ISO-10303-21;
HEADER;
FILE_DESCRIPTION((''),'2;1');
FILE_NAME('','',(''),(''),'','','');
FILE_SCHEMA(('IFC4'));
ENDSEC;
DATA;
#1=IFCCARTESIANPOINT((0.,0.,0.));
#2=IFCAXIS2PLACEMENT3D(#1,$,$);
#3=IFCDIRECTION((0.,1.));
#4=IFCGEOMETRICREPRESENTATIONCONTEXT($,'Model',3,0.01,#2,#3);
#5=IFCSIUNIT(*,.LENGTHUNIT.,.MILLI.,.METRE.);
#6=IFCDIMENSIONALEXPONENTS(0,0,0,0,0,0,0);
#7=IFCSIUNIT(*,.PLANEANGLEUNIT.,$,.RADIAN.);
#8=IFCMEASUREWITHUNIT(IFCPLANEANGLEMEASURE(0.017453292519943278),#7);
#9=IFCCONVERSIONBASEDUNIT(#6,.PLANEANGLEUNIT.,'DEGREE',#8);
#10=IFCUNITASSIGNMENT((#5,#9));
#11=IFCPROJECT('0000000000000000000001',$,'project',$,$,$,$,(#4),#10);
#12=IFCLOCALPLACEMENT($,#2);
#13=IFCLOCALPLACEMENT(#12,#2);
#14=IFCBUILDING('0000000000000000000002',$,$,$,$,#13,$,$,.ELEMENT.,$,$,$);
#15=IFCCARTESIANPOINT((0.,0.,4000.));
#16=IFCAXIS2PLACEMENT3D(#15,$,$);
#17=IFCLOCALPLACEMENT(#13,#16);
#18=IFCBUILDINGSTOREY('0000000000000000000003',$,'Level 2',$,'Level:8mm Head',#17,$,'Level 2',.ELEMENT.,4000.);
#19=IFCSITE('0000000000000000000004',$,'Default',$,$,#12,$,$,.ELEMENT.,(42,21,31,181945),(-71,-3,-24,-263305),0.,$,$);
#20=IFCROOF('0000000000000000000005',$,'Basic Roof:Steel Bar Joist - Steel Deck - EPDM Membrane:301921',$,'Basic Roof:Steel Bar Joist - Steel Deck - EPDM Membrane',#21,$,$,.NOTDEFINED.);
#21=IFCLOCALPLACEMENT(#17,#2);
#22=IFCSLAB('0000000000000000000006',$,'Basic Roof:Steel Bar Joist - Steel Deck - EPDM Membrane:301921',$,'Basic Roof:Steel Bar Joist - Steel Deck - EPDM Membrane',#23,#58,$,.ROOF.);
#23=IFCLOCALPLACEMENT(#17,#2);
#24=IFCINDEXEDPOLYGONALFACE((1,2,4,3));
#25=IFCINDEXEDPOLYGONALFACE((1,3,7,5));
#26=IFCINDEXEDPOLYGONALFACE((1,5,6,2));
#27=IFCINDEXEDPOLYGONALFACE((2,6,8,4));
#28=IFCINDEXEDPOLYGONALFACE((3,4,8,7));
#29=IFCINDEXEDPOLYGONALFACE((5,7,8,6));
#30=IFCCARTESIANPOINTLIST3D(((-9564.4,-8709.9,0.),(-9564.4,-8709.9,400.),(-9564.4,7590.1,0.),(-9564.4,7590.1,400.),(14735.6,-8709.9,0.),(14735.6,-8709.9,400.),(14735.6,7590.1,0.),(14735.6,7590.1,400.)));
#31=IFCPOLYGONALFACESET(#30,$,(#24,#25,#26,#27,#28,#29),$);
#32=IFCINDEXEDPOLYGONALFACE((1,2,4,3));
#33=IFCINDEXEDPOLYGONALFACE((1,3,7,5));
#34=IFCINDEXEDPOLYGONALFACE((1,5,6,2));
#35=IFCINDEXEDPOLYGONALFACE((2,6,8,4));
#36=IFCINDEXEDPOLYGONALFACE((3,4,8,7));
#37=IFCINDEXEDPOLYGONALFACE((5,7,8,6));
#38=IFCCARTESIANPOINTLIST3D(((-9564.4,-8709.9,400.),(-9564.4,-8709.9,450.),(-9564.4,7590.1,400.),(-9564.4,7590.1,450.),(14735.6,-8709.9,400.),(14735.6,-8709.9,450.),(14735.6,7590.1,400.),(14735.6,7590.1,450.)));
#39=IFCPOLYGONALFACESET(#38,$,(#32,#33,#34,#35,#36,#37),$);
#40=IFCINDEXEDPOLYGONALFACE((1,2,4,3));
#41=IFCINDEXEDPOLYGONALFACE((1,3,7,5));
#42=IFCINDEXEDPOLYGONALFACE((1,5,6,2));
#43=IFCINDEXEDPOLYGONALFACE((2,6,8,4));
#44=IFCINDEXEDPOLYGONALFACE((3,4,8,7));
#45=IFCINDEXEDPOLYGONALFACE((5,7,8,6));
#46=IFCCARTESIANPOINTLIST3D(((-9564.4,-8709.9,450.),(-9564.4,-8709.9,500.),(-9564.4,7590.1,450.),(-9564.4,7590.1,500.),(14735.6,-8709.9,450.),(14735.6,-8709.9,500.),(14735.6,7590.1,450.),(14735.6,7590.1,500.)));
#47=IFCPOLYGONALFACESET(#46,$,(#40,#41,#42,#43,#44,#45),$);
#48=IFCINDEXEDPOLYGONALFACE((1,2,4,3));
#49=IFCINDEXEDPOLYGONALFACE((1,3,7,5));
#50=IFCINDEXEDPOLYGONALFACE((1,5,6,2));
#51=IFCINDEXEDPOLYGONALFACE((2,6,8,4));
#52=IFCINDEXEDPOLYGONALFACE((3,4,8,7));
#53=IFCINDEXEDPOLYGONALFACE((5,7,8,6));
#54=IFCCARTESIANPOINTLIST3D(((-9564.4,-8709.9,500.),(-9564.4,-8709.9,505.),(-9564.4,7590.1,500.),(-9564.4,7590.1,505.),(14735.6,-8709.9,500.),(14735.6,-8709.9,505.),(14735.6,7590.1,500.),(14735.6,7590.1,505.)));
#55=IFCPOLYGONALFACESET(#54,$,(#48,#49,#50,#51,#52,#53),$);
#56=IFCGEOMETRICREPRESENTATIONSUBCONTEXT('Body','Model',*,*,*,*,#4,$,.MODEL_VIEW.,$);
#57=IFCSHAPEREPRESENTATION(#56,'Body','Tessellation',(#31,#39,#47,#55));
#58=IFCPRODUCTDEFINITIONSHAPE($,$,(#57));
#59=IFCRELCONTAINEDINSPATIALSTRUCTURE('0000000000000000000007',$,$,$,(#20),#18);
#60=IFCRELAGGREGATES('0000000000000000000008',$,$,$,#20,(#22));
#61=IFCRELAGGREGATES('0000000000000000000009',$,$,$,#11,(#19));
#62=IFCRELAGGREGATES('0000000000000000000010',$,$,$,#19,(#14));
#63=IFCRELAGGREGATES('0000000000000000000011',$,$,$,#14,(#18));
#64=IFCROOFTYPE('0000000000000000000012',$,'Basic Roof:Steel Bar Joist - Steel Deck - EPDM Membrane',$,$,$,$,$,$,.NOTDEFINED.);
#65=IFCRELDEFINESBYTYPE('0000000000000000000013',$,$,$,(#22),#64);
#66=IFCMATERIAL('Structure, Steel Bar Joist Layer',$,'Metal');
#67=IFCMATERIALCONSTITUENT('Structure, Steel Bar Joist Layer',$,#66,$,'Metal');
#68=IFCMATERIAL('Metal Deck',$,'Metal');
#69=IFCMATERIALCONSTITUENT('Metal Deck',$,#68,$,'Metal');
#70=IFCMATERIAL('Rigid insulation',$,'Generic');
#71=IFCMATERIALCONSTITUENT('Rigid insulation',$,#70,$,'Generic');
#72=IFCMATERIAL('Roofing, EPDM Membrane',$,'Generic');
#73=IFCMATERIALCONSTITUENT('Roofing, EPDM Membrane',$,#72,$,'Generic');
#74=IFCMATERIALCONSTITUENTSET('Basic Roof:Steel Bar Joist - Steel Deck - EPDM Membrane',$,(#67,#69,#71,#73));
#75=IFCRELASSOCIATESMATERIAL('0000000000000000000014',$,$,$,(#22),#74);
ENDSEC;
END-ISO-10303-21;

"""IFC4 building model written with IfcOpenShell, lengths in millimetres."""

from ifc_helpers import new_model, entity, si_unit, converted_unit, direction, frame, origin, place, context, subcontext, project, spatial, indexed_curve, outline, extrude, material, constituent, constituent_set, type_object, element, aggregate, save


model = new_model("IFC4")

# Units and contexts
model_context = context("Model", 3, precision=0.01, world=origin(), true_north=direction((0.0, 1.0)))
body_context = subcontext(model_context, "Body", "Model", "MODEL_VIEW")
ifc_project = project(units=[si_unit("LENGTHUNIT", "METRE", prefix="MILLI"), converted_unit("PLANEANGLEUNIT", "DEGREE", entity("IfcPlaneAngleMeasure", 0.017453292519943278), si_unit("PLANEANGLEUNIT", "RADIAN"), dimensions=[0, 0, 0, 0, 0, 0, 0])], contexts=[model_context])

# Site, building, storey
site_placement = place(None, origin())
site = spatial("IfcSite", under=ifc_project, at=site_placement, Name="Default", CompositionType="ELEMENT", RefLatitude=(42, 21, 31, 181945), RefLongitude=(-71, -3, -24, -263305), RefElevation=0.0)
building_placement = place(site_placement, origin())
building = spatial("IfcBuilding", under=site, at=building_placement, CompositionType="ELEMENT")
storey_placement = place(building_placement, frame((0.0, 0.0, 4000.0)))
storey = spatial("IfcBuildingStorey", under=building, at=storey_placement, Name="Level 2", ObjectType="Level:8mm Head", LongName="Level 2", CompositionType="ELEMENT", Elevation=4000.0)

# Roof, slab
roof_placement = place(storey_placement, frame((-9564.4, -8709.9, 0.0)))
roof = element("IfcRoof", 1, at=roof_placement, inside=storey, Name="Basic Roof:Steel Bar Joist - Steel Deck - EPDM Membrane:301921", ObjectType="Basic Roof:Steel Bar Joist - Steel Deck - EPDM Membrane", PredefinedType="NOTDEFINED")
ifc_material_1 = material(Name="Structure, Steel Bar Joist Layer", Category="Metal")
ifc_constituent_1 = constituent(ifc_material_1, Name="Structure, Steel Bar Joist Layer", Category="Metal")
ifc_material_2 = material(Name="Metal Deck", Category="Metal")
ifc_constituent_2 = constituent(ifc_material_2, Name="Metal Deck", Category="Metal")
ifc_material_3 = material(Name="Rigid insulation", Category="Generic")
ifc_constituent_3 = constituent(ifc_material_3, Name="Rigid insulation", Category="Generic")
ifc_material_4 = material(Name="Roofing, EPDM Membrane", Category="Generic")
ifc_constituent_4 = constituent(ifc_material_4, Name="Roofing, EPDM Membrane", Category="Generic")
ifc_constituent_set = constituent_set(constituents=[ifc_constituent_1, ifc_constituent_2, ifc_constituent_3, ifc_constituent_4], Name="Basic Roof:Steel Bar Joist - Steel Deck - EPDM Membrane")
roof_type = type_object("IfcRoofType", Name="Basic Roof:Steel Bar Joist - Steel Deck - EPDM Membrane", PredefinedType="NOTDEFINED")
slab_placement = place(roof_placement, origin())
slab = element("IfcSlab", 2, at=slab_placement, type_object=roof_type, material=ifc_constituent_set, Name="Basic Roof:Steel Bar Joist - Steel Deck - EPDM Membrane:301921", ObjectType="Basic Roof:Steel Bar Joist - Steel Deck - EPDM Membrane", PredefinedType="ROOF", context=body_context, shape_type="SweptSolid", body=[
    extrude(outline(indexed_curve([(-12150.0, 8150.0), (-12150.0, -8150.0), (12150.0, -8150.0), (12150.0, 8150.0), (-12150.0, 8150.0)], self_intersect=False)), frame((12150.0, 8150.0, 0.0)), (0.0, 0.0, 1.0), 400.0),
    extrude(outline(indexed_curve([(-12150.0, 8150.0), (-12150.0, -8150.0), (12150.0, -8150.0), (12150.0, 8150.0), (-12150.0, 8150.0)], self_intersect=False)), frame((12150.0, 8150.0, 400.0)), (0.0, 0.0, 1.0), 50.0),
    extrude(outline(indexed_curve([(-12150.0, 8150.0), (-12150.0, -8150.0), (12150.0, -8150.0), (12150.0, 8150.0), (-12150.0, 8150.0)], self_intersect=False)), frame((12150.0, 8150.0, 450.0)), (0.0, 0.0, 1.0), 50.0),
    extrude(outline(indexed_curve([(-12150.0, 8150.0), (-12150.0, -8150.0), (12150.0, -8150.0), (12150.0, 8150.0), (-12150.0, 8150.0)], self_intersect=False)), frame((12150.0, 8150.0, 500.0)), (0.0, 0.0, 1.0), 5.0),
])
aggregate(roof, [slab])

save(model, "model.ifc")
